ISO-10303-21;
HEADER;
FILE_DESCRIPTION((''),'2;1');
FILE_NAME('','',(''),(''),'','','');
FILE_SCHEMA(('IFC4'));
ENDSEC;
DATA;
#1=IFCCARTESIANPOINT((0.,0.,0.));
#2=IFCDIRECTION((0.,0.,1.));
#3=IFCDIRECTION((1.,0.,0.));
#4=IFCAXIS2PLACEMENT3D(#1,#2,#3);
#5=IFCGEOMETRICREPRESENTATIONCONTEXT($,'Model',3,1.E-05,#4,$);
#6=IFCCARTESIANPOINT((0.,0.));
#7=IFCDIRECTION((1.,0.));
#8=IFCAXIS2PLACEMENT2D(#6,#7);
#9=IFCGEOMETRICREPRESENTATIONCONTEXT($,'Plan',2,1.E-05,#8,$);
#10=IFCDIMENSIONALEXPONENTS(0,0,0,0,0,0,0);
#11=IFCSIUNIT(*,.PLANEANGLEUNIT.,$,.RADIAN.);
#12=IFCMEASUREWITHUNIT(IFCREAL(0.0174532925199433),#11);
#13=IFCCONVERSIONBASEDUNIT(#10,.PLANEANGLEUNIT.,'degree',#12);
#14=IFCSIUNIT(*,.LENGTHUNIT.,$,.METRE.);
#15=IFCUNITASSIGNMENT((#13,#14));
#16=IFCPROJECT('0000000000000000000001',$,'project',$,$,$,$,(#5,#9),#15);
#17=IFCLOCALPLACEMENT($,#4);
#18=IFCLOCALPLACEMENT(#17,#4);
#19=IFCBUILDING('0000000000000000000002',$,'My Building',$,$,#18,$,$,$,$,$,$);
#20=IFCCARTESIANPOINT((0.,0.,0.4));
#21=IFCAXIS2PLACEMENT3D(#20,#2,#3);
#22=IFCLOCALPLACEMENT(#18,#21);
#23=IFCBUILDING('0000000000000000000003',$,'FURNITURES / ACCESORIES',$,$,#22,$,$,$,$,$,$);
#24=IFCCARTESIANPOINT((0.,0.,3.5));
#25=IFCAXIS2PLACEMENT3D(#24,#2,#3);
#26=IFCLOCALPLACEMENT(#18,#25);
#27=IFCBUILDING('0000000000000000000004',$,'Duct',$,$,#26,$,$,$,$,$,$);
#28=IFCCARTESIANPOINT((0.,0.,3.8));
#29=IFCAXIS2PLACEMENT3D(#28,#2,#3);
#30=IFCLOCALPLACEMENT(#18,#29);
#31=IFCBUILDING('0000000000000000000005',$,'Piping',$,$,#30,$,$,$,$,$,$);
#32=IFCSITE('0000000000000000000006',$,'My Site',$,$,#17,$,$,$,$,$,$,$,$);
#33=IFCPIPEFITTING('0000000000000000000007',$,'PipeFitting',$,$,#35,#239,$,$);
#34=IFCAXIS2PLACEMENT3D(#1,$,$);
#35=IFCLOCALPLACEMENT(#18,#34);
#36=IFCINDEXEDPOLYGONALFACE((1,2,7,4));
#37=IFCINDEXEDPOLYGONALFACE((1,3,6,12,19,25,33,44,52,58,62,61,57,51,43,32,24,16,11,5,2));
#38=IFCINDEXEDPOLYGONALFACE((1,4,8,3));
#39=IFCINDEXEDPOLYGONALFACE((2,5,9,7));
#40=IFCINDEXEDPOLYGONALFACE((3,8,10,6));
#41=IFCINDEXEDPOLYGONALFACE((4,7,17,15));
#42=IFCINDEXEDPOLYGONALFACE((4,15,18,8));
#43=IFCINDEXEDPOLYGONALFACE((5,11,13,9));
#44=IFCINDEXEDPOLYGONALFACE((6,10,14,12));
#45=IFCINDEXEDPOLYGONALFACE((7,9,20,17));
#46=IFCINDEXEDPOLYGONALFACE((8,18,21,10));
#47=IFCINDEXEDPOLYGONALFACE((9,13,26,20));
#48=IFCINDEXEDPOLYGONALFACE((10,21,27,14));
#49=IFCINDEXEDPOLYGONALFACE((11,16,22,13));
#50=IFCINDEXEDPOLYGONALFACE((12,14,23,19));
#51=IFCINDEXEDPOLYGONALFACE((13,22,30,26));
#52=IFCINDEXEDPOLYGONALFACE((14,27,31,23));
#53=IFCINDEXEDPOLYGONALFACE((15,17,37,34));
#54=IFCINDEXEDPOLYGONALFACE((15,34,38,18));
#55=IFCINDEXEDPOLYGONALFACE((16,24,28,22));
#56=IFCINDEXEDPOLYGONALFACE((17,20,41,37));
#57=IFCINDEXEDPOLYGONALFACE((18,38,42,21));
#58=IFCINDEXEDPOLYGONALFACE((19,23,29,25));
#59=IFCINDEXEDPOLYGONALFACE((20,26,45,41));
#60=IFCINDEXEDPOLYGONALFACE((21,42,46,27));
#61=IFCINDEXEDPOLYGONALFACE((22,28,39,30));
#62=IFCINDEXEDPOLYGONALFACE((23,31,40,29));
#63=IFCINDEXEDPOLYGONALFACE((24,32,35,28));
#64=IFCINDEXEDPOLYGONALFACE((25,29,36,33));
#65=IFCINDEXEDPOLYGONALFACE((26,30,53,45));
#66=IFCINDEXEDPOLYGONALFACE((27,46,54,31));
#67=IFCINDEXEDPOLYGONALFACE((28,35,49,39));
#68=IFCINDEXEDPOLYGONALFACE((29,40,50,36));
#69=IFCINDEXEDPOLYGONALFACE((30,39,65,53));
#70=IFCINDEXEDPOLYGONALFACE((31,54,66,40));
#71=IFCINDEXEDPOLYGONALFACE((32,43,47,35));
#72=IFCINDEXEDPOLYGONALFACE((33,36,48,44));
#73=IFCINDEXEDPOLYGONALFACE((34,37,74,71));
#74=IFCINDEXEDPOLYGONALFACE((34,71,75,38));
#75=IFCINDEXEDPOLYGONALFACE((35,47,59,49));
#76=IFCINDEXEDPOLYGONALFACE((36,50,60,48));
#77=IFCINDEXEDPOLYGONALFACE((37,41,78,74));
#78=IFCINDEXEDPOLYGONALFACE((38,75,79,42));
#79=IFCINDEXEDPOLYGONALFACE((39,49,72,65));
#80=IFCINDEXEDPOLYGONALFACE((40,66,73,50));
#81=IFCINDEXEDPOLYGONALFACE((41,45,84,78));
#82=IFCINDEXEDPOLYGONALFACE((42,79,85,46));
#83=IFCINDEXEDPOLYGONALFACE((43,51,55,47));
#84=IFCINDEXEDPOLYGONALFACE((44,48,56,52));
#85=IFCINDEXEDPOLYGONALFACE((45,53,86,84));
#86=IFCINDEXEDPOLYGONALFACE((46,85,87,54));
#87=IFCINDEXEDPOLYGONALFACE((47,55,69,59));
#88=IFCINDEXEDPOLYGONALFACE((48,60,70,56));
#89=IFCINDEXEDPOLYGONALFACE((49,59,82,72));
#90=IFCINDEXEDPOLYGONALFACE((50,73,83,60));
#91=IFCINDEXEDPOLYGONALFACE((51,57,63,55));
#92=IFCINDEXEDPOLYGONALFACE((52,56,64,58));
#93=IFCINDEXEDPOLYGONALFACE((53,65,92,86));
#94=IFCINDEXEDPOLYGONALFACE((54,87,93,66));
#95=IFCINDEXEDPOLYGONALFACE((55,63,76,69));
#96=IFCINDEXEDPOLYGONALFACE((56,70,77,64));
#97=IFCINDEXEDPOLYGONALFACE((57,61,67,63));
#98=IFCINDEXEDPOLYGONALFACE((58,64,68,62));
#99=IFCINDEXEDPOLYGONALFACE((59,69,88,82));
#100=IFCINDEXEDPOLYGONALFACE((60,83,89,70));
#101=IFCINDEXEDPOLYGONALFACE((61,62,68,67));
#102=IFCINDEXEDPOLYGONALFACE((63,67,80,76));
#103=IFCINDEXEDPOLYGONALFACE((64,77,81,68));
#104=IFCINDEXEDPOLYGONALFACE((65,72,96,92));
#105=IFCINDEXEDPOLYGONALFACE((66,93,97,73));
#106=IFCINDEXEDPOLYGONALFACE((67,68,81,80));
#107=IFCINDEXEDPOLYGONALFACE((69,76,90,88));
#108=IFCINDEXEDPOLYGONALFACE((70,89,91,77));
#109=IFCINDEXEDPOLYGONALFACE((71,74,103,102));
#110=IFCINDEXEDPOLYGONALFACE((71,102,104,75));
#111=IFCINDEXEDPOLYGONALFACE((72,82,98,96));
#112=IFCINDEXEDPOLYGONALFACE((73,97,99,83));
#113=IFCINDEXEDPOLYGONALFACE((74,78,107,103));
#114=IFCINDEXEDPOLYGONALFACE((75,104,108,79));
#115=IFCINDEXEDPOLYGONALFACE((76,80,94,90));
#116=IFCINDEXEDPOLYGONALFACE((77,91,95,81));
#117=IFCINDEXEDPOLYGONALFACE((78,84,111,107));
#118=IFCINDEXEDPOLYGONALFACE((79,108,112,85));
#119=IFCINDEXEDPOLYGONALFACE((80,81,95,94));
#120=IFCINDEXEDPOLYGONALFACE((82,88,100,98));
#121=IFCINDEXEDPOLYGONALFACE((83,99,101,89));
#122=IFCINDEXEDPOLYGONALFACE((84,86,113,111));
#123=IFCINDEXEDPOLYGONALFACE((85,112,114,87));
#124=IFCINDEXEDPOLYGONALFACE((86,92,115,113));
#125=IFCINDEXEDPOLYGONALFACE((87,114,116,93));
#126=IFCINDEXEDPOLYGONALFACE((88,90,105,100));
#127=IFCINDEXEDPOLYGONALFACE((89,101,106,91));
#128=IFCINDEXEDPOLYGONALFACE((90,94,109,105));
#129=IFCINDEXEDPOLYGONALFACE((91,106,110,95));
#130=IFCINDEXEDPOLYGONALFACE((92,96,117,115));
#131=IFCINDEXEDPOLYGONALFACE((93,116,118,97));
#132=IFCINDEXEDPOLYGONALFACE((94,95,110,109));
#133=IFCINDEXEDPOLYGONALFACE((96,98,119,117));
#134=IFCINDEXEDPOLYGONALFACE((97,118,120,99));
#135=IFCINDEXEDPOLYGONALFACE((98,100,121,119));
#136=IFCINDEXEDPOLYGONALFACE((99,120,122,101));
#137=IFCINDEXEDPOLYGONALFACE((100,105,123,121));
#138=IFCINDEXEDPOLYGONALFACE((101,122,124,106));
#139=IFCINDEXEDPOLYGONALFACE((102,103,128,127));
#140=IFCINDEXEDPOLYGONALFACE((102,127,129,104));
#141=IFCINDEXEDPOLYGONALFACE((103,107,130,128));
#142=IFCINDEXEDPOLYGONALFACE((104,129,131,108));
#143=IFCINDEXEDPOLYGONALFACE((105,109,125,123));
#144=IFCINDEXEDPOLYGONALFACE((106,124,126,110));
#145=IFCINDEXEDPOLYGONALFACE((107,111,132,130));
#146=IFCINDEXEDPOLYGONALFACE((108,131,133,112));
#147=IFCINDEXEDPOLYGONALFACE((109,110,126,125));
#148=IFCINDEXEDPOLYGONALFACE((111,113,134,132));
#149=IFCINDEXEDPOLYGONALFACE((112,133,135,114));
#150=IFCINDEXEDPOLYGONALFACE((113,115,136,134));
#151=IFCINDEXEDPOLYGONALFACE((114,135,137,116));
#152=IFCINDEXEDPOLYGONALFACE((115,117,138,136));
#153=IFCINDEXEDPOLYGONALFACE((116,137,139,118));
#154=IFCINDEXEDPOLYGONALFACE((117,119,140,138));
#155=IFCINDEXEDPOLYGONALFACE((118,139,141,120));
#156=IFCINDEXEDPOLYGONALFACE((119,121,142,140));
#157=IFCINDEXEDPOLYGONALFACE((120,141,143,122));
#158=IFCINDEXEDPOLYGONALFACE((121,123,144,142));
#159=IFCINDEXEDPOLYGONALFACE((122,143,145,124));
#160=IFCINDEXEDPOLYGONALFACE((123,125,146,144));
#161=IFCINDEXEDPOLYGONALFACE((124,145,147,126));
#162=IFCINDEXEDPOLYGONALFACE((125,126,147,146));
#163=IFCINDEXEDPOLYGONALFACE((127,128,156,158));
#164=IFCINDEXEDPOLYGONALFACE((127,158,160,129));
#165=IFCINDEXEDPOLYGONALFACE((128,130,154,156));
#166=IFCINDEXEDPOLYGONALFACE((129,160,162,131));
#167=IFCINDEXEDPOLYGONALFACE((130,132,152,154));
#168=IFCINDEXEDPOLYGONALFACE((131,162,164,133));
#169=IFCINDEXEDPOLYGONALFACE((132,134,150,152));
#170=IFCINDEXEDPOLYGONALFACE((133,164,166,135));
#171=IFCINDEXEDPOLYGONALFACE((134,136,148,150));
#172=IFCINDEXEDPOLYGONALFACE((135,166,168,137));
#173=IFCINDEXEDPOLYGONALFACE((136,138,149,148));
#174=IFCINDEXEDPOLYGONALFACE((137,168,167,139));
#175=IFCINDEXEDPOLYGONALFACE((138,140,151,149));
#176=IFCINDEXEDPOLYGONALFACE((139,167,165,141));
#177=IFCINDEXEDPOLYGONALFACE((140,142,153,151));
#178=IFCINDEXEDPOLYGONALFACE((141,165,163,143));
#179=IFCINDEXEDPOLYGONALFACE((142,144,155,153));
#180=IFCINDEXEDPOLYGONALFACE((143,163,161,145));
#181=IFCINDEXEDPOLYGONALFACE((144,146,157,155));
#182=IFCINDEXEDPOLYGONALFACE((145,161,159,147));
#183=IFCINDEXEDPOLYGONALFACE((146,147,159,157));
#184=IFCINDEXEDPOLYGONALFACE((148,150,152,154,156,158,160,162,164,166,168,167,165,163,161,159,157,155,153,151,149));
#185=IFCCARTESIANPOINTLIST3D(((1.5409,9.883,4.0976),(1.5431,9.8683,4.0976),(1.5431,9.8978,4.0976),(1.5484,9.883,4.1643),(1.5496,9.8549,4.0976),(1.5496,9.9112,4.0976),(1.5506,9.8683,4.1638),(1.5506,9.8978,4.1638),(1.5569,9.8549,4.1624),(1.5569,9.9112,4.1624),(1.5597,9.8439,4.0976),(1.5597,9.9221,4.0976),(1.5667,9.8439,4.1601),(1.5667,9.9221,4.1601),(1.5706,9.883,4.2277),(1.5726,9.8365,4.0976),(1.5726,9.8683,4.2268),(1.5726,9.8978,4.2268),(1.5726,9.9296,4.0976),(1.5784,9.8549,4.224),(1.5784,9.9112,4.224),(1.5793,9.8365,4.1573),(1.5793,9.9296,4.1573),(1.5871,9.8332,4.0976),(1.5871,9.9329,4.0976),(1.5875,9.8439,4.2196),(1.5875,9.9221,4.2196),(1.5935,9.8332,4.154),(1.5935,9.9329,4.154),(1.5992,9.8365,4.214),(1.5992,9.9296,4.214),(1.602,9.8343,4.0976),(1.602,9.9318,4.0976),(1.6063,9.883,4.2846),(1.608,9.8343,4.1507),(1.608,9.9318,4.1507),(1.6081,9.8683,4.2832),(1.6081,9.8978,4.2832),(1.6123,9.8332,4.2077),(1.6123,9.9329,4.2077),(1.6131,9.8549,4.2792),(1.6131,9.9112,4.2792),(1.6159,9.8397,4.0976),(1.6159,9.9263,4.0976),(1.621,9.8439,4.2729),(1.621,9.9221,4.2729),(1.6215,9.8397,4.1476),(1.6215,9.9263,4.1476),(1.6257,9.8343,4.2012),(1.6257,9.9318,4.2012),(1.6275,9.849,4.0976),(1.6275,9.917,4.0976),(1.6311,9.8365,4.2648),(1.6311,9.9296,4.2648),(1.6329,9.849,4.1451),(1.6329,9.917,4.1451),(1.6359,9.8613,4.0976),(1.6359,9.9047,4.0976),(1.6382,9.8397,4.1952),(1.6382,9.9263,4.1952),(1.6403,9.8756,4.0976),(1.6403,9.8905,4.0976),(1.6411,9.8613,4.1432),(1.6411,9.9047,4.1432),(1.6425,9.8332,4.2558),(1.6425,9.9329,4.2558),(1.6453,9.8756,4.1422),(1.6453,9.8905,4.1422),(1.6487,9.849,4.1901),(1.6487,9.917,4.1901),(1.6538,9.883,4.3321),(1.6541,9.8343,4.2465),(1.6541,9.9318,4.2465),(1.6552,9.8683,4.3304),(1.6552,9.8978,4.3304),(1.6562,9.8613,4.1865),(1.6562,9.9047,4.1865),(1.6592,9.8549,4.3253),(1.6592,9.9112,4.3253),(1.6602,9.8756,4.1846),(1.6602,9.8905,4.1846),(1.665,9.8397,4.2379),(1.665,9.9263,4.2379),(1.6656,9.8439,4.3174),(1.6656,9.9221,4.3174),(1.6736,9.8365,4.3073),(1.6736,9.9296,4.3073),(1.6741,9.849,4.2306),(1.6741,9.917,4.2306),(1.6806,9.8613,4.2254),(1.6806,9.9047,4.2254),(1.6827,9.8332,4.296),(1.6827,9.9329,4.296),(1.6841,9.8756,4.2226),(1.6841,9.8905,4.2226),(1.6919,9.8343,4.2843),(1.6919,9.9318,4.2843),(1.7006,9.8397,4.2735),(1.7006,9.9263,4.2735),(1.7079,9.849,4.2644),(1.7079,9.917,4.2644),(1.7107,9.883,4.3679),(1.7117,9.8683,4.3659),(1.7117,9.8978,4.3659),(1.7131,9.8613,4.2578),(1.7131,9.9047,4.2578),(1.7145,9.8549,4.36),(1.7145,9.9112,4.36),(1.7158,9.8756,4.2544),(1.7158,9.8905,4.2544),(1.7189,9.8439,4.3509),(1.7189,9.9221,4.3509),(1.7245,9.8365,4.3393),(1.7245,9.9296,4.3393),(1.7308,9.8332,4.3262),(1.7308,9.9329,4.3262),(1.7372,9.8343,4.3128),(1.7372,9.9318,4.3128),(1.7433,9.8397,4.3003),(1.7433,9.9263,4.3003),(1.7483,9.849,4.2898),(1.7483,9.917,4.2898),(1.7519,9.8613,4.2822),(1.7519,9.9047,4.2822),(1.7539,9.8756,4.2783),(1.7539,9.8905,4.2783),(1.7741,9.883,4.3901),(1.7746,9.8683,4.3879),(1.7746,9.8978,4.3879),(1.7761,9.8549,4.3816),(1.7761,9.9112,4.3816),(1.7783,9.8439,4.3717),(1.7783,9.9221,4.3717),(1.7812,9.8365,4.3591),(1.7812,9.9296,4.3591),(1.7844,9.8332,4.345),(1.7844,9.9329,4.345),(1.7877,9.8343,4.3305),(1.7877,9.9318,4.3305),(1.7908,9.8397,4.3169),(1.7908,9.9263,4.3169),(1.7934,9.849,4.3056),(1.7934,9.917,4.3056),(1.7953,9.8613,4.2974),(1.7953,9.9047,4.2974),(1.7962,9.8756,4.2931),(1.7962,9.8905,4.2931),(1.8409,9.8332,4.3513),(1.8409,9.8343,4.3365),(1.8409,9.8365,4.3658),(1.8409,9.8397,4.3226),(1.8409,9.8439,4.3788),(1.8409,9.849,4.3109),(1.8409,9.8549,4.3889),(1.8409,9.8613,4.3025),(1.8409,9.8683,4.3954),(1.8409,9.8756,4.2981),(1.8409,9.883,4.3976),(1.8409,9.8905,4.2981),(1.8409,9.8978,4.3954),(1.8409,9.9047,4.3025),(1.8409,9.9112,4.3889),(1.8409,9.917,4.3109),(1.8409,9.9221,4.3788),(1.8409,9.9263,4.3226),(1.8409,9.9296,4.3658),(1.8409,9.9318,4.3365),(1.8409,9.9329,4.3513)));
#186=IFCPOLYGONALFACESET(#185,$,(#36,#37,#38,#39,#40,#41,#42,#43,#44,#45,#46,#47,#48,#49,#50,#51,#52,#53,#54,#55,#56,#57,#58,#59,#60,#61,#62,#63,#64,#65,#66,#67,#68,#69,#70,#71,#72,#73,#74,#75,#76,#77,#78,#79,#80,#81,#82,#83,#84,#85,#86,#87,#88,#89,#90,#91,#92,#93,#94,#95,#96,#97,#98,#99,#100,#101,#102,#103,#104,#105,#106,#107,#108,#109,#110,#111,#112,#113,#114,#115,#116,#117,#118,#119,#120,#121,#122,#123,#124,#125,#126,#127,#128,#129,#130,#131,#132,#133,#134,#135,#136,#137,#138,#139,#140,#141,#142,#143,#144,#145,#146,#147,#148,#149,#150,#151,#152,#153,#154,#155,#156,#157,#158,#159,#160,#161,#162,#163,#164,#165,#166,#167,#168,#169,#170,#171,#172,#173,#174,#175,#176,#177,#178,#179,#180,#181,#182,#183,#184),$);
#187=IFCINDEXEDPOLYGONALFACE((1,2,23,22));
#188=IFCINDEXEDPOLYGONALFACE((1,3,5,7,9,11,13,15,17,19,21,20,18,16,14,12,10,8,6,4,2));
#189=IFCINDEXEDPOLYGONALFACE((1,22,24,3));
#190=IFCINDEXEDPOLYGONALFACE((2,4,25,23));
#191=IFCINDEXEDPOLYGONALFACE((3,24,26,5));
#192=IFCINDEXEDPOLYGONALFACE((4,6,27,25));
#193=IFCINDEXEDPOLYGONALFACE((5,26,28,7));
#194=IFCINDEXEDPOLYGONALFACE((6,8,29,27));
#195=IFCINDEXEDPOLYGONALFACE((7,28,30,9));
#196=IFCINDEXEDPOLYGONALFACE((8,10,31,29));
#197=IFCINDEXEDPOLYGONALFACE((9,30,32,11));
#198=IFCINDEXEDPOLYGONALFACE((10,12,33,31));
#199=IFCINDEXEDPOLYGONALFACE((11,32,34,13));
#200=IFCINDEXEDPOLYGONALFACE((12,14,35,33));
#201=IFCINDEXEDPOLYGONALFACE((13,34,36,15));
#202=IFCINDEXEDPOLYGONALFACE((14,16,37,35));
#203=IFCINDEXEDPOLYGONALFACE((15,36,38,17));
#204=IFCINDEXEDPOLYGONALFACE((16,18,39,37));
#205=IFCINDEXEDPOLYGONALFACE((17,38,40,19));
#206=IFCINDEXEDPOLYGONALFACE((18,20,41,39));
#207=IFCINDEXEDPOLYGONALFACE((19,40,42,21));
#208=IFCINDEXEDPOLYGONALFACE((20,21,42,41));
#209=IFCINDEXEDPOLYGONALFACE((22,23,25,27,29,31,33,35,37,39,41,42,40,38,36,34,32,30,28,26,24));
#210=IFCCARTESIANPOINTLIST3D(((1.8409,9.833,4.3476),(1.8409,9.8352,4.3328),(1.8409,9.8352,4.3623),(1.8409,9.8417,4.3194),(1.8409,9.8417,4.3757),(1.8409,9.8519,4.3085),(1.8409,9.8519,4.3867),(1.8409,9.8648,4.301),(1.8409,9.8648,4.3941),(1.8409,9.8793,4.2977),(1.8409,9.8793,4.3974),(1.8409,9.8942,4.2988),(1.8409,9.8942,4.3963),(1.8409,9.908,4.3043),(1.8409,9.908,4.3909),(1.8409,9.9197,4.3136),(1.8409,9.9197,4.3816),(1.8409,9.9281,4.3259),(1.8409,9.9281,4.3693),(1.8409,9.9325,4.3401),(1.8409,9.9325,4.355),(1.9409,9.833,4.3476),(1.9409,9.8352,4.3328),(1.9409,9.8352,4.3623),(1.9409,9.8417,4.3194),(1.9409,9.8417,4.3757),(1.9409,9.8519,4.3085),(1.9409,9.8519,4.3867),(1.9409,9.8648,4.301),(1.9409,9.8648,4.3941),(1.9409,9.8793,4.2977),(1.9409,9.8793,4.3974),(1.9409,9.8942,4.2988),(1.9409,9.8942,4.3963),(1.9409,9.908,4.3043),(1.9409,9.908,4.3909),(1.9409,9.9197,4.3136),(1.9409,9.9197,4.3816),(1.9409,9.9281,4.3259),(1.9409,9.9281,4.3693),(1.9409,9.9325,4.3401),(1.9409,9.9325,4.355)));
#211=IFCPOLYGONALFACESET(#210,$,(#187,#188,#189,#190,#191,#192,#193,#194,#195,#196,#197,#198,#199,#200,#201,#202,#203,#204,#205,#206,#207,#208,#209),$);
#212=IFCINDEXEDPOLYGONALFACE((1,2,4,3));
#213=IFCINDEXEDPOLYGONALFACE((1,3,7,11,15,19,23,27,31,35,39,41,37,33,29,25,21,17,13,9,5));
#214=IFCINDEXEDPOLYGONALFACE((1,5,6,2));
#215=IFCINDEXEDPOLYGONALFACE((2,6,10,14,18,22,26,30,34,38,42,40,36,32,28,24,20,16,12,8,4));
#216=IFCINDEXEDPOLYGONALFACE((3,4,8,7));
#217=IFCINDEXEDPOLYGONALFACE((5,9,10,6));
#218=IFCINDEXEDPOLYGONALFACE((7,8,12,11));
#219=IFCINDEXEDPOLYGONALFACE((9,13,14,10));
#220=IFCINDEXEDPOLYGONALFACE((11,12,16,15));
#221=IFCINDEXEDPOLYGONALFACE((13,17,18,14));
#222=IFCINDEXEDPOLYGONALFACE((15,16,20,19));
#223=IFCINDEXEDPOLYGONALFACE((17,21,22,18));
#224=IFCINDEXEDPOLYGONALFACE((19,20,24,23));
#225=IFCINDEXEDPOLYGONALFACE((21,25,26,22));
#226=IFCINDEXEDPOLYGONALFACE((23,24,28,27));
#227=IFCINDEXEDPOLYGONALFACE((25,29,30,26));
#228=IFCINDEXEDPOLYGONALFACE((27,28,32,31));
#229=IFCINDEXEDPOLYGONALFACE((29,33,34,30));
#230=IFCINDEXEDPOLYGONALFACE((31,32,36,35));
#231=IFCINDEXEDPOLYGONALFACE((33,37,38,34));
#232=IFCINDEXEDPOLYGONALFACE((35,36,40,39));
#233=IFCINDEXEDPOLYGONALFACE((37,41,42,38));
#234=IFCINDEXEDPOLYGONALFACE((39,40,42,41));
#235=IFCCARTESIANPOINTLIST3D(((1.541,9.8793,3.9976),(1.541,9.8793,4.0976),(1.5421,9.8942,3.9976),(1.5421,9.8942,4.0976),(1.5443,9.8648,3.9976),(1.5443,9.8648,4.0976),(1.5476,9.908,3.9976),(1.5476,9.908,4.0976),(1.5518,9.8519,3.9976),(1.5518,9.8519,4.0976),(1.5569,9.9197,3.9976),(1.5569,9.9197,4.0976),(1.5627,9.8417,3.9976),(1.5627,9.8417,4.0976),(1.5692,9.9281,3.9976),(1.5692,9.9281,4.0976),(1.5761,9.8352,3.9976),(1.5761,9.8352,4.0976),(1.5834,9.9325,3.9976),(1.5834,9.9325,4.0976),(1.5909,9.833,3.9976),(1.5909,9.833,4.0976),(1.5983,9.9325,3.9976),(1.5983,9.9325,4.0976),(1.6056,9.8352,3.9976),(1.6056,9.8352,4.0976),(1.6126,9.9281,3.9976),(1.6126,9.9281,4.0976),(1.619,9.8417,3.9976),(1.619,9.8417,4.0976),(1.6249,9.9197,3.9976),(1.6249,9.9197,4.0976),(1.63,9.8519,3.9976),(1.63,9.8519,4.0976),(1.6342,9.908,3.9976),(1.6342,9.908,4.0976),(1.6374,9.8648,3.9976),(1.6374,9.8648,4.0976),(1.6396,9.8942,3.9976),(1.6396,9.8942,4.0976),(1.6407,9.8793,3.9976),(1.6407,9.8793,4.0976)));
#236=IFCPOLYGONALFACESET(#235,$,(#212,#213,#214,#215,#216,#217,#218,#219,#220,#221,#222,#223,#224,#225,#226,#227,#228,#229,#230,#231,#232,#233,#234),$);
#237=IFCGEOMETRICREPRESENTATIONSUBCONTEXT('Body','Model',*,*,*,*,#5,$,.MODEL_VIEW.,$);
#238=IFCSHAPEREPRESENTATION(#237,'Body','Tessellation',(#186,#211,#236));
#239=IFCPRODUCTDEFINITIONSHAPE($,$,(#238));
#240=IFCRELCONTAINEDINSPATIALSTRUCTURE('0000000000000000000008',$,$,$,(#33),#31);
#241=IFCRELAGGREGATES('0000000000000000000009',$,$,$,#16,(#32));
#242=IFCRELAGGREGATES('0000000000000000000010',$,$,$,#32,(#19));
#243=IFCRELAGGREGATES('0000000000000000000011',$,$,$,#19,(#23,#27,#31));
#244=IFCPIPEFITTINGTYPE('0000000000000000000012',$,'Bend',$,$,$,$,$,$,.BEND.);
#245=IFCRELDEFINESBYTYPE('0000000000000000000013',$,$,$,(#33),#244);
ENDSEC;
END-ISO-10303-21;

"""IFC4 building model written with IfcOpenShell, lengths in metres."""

from ifc_helpers import new_model, entity, si_unit, converted_unit, frame, origin_with_axes, origin_2d_with_axis, place, context, subcontext, project, spatial, circle, extrude, source, transform, mapped, type_object, type_shapes, element, save


model = new_model("IFC4")

# Units and contexts
model_context = context("Model", 3, precision=1e-05, world=origin_with_axes())
plan_context = context("Plan", 2, precision=1e-05, world=origin_2d_with_axis())
body_context = subcontext(model_context, "Body", "Model", "MODEL_VIEW")
ifc_project = project(units=[converted_unit("PLANEANGLEUNIT", "degree", entity("IfcReal", 0.0174532925199433), si_unit("PLANEANGLEUNIT", "RADIAN"), dimensions=[0, 0, 0, 0, 0, 0, 0]), si_unit("LENGTHUNIT", "METRE")], contexts=[model_context, plan_context])

# Site, building
site_placement = place(None, origin_with_axes())
site = spatial("IfcSite", under=ifc_project, at=site_placement, Name="My Site")
building_1_placement = place(site_placement, origin_with_axes())
building_1 = spatial("IfcBuilding", under=site, at=building_1_placement, Name="My Building")

# Shared definitions
building_2_placement = place(building_1_placement, frame((0.0, 0.0, 0.4), z_axis=(0.0, 0.0, 1.0), x_axis=(1.0, 0.0, 0.0)))
building_2 = spatial("IfcBuilding", under=building_1, at=building_2_placement, Name="FURNITURES / ACCESORIES")

# Shared definitions
building_3_placement = place(building_1_placement, frame((0.0, 0.0, 3.5), z_axis=(0.0, 0.0, 1.0), x_axis=(1.0, 0.0, 0.0)))
building_3 = spatial("IfcBuilding", under=building_1, at=building_3_placement, Name="Duct")

# Shared definitions
building_4_placement = place(building_1_placement, frame((0.0, 0.0, 3.8), z_axis=(0.0, 0.0, 1.0), x_axis=(1.0, 0.0, 0.0)))
building_4 = spatial("IfcBuilding", under=building_1, at=building_4_placement, Name="Piping")

# Pipe fitting
pipe_fitting_type_1 = type_object("IfcPipeFittingType", Name="Bend", PredefinedType="BEND")
shared_shape = source(origin_with_axes(), body_context, "Body", "SolidModel", [
    entity("IfcSweptDiskSolid", entity("IfcIndexedPolyCurve", entity("IfcCartesianPointList3D", [[0.0, 0.0, 0.1], [0.0, -0.0732, 0.2768], [0.0, -0.25, 0.35]]), [entity("IfcArcIndex", [1, 2, 3])]), 0.05),
    extrude(circle(Radius=0.05), origin_with_axes(), (0.0, 0.0, 1.0), 0.1),
    extrude(circle(Radius=0.05), frame((0.0, -0.25, 0.35), z_axis=(0.0, -1.0, -0.000001), x_axis=(1.0, 0.0, 0.0)), (0.0, 0.0, 1.0), 0.1),
])
type_shapes(pipe_fitting_type_1, [shared_shape])
for number, where, z_axis, x_axis, name in (
    (1, (1.9409, 9.883, 0.5476), (-1.0, 0.000001, -0.000001), (-0.000001, -1.0, 0.0), "PipeFitting"),
):
    element("IfcPipeFitting", number, at=place(building_4_placement, frame(where, z_axis=z_axis, x_axis=x_axis)), inside=building_4, type_object=pipe_fitting_type_1, Name=name, context=body_context, shape_type="MappedRepresentation", body=[
        mapped(shared_shape, transform((0.0, 0.0, 0.0), x_axis=(1.0, 0.0, 0.0), y_axis=(0.0, 1.0, 0.0), z_axis=(0.0, 0.0, 1.0), scale=1.0)),
    ])

save(model, "model.ifc")
